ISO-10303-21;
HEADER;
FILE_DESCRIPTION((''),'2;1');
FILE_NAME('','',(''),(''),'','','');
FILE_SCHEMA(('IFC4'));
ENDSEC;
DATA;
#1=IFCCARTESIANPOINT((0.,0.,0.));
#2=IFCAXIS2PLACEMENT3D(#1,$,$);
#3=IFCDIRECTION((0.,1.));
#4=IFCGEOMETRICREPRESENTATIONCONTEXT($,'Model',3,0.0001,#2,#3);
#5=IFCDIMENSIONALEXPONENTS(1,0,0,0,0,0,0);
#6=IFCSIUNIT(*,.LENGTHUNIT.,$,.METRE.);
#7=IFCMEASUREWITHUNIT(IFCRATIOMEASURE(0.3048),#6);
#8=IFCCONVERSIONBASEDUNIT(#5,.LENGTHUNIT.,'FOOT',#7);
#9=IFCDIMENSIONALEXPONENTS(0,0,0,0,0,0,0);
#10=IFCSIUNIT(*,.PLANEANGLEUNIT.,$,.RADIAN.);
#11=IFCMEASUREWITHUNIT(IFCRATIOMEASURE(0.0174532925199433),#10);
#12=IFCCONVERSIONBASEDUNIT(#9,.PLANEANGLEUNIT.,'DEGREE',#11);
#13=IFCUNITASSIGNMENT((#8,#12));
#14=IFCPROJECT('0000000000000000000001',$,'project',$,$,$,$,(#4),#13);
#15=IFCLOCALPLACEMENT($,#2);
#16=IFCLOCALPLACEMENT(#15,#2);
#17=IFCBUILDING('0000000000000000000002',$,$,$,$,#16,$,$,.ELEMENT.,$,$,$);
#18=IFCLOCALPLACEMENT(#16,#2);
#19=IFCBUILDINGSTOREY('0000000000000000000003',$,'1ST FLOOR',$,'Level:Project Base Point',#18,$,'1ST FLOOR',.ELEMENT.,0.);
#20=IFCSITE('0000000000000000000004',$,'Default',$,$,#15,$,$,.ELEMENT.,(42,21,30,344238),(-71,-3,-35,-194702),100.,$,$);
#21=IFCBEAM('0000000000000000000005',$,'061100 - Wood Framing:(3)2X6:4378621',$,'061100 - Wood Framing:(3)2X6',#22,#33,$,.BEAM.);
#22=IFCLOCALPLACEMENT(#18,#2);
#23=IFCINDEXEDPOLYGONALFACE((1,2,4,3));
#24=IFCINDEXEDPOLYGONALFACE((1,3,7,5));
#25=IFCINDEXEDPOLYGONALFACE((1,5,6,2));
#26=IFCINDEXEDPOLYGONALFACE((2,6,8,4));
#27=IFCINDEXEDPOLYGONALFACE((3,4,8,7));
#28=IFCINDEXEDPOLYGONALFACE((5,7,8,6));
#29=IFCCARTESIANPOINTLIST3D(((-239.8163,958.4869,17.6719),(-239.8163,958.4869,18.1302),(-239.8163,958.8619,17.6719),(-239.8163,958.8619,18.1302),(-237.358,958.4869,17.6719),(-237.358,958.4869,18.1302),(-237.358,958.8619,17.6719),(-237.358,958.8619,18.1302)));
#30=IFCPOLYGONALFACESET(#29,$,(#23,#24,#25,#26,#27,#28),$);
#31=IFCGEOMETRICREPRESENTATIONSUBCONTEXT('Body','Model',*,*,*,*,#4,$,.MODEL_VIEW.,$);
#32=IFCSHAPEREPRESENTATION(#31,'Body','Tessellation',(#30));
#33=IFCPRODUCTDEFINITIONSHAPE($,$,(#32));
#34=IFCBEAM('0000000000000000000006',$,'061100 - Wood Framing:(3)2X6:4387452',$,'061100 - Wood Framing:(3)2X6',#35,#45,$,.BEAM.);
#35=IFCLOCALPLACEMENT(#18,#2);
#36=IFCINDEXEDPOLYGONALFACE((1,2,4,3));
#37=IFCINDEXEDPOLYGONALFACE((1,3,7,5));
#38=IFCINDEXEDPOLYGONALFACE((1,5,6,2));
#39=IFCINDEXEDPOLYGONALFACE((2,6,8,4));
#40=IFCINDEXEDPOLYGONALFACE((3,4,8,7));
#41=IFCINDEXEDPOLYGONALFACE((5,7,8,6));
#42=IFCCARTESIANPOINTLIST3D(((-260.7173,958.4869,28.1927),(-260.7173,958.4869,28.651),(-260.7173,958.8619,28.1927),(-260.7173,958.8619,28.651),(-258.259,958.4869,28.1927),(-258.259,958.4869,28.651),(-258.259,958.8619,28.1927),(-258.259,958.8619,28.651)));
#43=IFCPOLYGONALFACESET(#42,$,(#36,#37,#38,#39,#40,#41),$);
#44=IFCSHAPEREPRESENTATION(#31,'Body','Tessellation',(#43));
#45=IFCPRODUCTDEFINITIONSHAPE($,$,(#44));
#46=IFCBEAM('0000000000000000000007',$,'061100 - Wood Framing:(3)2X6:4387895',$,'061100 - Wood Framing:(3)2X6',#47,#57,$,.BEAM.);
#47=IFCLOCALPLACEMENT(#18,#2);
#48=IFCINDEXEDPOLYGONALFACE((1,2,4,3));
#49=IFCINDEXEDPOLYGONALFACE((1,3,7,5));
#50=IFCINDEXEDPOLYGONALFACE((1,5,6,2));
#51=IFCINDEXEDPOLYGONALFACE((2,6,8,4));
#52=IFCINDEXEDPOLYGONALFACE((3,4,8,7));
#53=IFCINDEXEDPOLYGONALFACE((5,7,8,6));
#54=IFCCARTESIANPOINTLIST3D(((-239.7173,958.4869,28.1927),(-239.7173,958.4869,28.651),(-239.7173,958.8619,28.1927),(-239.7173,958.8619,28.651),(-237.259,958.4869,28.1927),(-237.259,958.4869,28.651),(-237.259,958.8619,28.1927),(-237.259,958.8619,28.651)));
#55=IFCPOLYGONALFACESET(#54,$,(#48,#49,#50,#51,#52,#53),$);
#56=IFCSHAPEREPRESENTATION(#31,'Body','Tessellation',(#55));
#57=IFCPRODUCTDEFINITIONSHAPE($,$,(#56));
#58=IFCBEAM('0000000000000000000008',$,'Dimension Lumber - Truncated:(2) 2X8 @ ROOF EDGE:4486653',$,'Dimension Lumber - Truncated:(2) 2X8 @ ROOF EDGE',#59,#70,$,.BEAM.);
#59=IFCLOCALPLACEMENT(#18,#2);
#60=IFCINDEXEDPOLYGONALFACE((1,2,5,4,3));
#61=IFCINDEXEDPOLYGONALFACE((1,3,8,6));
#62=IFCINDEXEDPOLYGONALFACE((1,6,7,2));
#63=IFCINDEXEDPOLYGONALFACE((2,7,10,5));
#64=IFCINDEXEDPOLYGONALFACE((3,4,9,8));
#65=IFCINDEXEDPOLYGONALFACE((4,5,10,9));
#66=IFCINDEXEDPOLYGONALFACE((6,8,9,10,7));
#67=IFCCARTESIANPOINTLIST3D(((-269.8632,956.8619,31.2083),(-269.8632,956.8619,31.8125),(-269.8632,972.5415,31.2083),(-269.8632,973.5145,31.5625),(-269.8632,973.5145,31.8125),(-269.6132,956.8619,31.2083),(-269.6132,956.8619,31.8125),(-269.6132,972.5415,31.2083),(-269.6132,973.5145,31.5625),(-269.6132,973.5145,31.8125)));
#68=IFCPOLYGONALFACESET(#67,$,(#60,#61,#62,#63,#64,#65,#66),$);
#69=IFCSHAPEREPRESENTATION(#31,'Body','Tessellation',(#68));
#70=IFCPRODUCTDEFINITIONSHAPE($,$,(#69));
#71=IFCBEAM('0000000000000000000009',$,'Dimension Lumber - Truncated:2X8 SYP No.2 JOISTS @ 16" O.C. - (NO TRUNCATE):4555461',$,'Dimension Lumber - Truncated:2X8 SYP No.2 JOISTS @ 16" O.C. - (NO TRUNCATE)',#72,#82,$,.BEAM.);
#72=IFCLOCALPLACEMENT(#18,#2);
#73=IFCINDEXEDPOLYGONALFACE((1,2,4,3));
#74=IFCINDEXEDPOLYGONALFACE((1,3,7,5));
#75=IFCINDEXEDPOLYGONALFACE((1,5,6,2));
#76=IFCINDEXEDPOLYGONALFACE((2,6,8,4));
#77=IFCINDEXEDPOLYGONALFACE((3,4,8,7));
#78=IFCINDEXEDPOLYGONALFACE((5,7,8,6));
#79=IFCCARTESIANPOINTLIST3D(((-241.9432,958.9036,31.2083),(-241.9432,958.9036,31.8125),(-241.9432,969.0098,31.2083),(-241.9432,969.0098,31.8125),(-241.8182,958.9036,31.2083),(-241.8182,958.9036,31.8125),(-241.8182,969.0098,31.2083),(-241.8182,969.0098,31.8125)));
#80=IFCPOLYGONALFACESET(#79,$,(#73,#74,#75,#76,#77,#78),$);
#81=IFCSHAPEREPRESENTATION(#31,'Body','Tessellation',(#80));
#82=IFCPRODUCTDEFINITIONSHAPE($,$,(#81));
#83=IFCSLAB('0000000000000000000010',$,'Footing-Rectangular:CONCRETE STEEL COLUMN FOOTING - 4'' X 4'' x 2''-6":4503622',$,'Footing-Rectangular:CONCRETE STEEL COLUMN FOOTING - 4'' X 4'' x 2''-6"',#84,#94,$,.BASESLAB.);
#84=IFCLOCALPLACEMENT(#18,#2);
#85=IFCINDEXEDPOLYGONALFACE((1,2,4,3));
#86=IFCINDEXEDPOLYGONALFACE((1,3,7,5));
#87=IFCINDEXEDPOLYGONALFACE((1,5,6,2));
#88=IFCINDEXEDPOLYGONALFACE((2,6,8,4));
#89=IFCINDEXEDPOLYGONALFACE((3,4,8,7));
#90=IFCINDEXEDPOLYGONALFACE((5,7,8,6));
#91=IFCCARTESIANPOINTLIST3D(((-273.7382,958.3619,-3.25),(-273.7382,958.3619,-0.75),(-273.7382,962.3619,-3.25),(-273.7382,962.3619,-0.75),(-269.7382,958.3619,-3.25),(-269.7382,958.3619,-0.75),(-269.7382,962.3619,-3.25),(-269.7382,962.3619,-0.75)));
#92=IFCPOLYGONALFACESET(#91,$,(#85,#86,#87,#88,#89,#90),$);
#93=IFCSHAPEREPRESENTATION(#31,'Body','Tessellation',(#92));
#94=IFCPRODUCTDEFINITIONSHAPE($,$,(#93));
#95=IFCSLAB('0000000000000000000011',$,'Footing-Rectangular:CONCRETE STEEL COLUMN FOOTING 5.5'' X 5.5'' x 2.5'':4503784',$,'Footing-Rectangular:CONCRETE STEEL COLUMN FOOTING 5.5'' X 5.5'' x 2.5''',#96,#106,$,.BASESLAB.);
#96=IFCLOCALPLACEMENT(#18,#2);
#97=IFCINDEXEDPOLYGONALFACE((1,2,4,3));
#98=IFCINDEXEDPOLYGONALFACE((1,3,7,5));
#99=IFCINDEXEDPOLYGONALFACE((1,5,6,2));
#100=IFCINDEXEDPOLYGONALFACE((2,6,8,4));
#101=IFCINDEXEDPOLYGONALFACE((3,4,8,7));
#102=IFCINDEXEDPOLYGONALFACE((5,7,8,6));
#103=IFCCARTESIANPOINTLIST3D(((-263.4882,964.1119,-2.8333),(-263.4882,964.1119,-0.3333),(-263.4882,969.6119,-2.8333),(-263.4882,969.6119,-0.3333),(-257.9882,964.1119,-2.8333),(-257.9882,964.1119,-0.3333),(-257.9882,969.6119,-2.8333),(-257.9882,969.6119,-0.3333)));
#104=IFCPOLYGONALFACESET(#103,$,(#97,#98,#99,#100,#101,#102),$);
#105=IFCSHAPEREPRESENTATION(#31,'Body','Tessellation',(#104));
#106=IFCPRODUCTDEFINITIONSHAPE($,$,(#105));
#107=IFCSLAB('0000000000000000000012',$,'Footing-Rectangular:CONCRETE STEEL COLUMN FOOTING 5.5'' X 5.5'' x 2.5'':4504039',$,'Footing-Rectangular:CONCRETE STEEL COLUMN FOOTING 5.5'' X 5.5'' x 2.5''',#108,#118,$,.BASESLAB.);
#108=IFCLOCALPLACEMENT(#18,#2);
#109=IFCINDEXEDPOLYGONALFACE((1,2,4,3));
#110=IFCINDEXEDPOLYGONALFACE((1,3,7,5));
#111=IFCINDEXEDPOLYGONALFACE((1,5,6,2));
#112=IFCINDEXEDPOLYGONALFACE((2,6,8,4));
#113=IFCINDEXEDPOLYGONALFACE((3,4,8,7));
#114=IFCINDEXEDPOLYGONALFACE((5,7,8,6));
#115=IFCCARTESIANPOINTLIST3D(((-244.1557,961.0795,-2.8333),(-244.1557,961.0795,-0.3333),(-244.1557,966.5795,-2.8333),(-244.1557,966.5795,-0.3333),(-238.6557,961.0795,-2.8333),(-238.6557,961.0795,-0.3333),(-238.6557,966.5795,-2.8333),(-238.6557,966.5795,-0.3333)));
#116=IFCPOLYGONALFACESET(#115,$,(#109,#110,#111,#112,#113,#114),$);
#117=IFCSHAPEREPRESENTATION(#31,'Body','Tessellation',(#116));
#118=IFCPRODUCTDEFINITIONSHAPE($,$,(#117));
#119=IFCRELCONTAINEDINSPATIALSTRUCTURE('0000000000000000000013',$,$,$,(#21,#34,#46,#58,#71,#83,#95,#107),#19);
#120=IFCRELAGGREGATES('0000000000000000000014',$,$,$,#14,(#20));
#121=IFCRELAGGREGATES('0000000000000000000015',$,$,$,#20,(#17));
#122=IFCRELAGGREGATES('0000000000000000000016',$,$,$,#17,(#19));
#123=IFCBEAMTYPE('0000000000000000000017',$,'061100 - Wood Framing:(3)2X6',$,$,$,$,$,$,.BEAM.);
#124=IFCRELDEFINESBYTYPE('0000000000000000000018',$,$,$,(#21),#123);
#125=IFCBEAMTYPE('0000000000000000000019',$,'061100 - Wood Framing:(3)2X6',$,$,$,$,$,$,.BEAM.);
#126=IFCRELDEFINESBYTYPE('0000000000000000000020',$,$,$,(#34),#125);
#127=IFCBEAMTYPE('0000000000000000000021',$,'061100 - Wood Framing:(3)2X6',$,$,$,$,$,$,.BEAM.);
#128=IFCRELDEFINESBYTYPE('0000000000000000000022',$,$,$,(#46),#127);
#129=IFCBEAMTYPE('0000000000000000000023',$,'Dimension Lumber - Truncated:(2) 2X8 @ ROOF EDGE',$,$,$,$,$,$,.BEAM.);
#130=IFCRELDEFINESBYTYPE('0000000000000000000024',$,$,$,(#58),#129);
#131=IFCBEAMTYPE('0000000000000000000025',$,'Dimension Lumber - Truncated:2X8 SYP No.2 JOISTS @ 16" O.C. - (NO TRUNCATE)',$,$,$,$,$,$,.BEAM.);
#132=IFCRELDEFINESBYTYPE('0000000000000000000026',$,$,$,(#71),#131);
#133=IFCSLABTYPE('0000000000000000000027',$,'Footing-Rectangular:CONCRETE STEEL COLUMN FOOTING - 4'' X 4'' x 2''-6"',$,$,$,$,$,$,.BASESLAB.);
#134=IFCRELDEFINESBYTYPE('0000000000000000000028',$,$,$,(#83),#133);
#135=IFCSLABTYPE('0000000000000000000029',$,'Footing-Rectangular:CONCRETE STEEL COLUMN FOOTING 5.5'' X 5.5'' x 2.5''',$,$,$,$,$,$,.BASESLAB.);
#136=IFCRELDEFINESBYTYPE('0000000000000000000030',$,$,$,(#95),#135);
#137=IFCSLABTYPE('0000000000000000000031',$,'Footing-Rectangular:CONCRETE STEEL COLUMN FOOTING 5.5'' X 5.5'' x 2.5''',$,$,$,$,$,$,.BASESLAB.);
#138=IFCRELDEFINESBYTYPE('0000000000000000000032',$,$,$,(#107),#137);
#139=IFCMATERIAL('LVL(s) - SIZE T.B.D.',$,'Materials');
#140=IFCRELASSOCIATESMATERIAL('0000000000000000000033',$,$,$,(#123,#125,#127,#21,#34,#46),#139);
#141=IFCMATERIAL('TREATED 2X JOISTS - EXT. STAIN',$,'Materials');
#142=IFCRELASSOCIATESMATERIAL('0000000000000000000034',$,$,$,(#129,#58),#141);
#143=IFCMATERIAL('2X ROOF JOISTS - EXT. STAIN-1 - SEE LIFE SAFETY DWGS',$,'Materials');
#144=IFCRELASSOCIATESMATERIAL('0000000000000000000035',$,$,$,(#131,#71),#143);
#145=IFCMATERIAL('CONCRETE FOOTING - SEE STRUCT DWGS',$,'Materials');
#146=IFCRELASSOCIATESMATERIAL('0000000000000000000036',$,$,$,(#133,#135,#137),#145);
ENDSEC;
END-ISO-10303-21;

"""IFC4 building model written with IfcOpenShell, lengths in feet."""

from ifc_helpers import new_model, entity, si_unit, converted_unit, direction, frame, frame_2d, origin, origin_2d_with_axis, place, context, subcontext, project, spatial, rectangle, extrude, clip, halfspace, source, transform, mapped, material, material_profile, profile_set, profile_usage, type_object, type_shapes, element, save


model = new_model("IFC4")

# Units and contexts
model_context = context("Model", 3, precision=0.0001, world=origin(), true_north=direction((0.0, 1.0)))
body_context = subcontext(model_context, "Body", "Model", "MODEL_VIEW")
ifc_project = project(units=[converted_unit("LENGTHUNIT", "FOOT", entity("IfcRatioMeasure", 0.3048), si_unit("LENGTHUNIT", "METRE"), dimensions=[1, 0, 0, 0, 0, 0, 0]), converted_unit("PLANEANGLEUNIT", "DEGREE", entity("IfcRatioMeasure", 0.0174532925199433), si_unit("PLANEANGLEUNIT", "RADIAN"), dimensions=[0, 0, 0, 0, 0, 0, 0])], contexts=[model_context])

# Site, building, storey
site_placement = place(None, origin())
site = spatial("IfcSite", under=ifc_project, at=site_placement, Name="Default", CompositionType="ELEMENT", RefLatitude=(42, 21, 30, 344238), RefLongitude=(-71, -3, -35, -194702), RefElevation=100.0)
building_placement = place(site_placement, origin())
building = spatial("IfcBuilding", under=site, at=building_placement, CompositionType="ELEMENT")
storey_placement = place(building_placement, origin())
storey = spatial("IfcBuildingStorey", under=building, at=storey_placement, Name="1ST FLOOR", ObjectType="Level:Project Base Point", LongName="1ST FLOOR", CompositionType="ELEMENT", Elevation=0.0)

# Beams
ifc_material_1 = material(Name="LVL(s) - SIZE T.B.D.", Category="Materials")
ifc_material_profile_1 = material_profile(ifc_material_1, rectangle(XDim=0.4583, YDim=0.375, at=frame_2d((0.0, 0.0), x_axis=(1.0, 0.0))), Name="(3)2X6")
ifc_profile_set_1 = profile_set([ifc_material_profile_1], Name="(3)2X6")
ifc_profile_usage_1 = profile_usage(ifc_profile_set_1, cardinal=8)
beam_type_1 = type_object("IfcBeamType", Name="061100 - Wood Framing:(3)2X6", PredefinedType="BEAM", material=ifc_profile_set_1)
shared_shape_1 = source(origin(), body_context, "Body", "SweptSolid", [
    extrude(rectangle(XDim=0.4583, YDim=0.375, at=frame_2d((0.0, 0.0), x_axis=(1.0, 0.0))), frame((-1.2169, 0.0, 0.0), z_axis=(1.0, 0.0, 0.0), x_axis=(0.0, 0.0, -1.0)), (0.0, 0.0, 1.0), 2.4583),
])
type_shapes(beam_type_1, [shared_shape_1])
beam_1_placement = place(storey_placement, frame((-238.5993, 958.6744, 17.901)))
element("IfcBeam", 1, at=beam_1_placement, inside=storey, type_object=beam_type_1, material=ifc_profile_usage_1, Name="061100 - Wood Framing:(3)2X6:4378621", ObjectType="061100 - Wood Framing:(3)2X6", PredefinedType="BEAM", context=body_context, shape_type="MappedRepresentation", body=[
    mapped(shared_shape_1, transform((0.0, 0.0, 0.0), scale=1.0)),
])
ifc_profile_usage_2 = profile_usage(ifc_profile_set_1, cardinal=8)
beam_type_2 = type_object("IfcBeamType", Name="061100 - Wood Framing:(3)2X6", PredefinedType="BEAM", material=ifc_profile_set_1)
shared_shape_2 = source(origin(), body_context, "Body", "SweptSolid", [
    extrude(rectangle(XDim=0.4583, YDim=0.375, at=origin_2d_with_axis()), frame((-1.2191, 0.0, 0.0), z_axis=(1.0, 0.0, 0.0), x_axis=(0.0, 0.0, -1.0)), (0.0, 0.0, 1.0), 2.4583),
])
type_shapes(beam_type_2, [shared_shape_2])
beam_2_placement = place(storey_placement, frame((-259.4983, 958.6744, 28.4219)))
element("IfcBeam", 2, at=beam_2_placement, inside=storey, type_object=beam_type_2, material=ifc_profile_usage_2, Name="061100 - Wood Framing:(3)2X6:4387452", ObjectType="061100 - Wood Framing:(3)2X6", PredefinedType="BEAM", context=body_context, shape_type="MappedRepresentation", body=[
    mapped(shared_shape_2, transform((0.0, 0.0, 0.0), scale=1.0)),
])
ifc_profile_usage_3 = profile_usage(ifc_profile_set_1, cardinal=8)
beam_type_3 = type_object("IfcBeamType", Name="061100 - Wood Framing:(3)2X6", PredefinedType="BEAM", material=ifc_profile_set_1)
shared_shape_3 = source(origin(), body_context, "Body", "SweptSolid", [
    extrude(rectangle(XDim=0.4583, YDim=0.375, at=frame_2d((0.0, 0.0), x_axis=(1.0, 0.0))), frame((-1.2357, 0.0, 0.0), z_axis=(1.0, 0.0, 0.0), x_axis=(0.0, 0.0, -1.0)), (0.0, 0.0, 1.0), 2.4583),
])
type_shapes(beam_type_3, [shared_shape_3])
beam_3_placement = place(storey_placement, frame((-238.4816, 958.6744, 28.4219)))
element("IfcBeam", 3, at=beam_3_placement, inside=storey, type_object=beam_type_3, material=ifc_profile_usage_3, Name="061100 - Wood Framing:(3)2X6:4387895", ObjectType="061100 - Wood Framing:(3)2X6", PredefinedType="BEAM", context=body_context, shape_type="MappedRepresentation", body=[
    mapped(shared_shape_3, transform((0.0, 0.0, 0.0), scale=1.0)),
])
ifc_material_2 = material(Name="TREATED 2X JOISTS - EXT. STAIN", Category="Materials")
ifc_material_profile_2 = material_profile(ifc_material_2, rectangle(XDim=0.6042, YDim=0.25, at=frame_2d((0.0, 0.0), x_axis=(0.0, 1.0))), Name="(2) 2X8 @ ROOF EDGE")
ifc_profile_set_2 = profile_set([ifc_material_profile_2], Name="(2) 2X8 @ ROOF EDGE")
ifc_profile_usage_4 = profile_usage(ifc_profile_set_2, cardinal=8)
beam_type_4 = type_object("IfcBeamType", Name="Dimension Lumber - Truncated:(2) 2X8 @ ROOF EDGE", PredefinedType="BEAM", material=ifc_profile_set_2)
shared_shape_4 = source(origin(), body_context, "Body", "Clipping", [
    clip(extrude(rectangle(XDim=0.6042, YDim=0.25, at=frame_2d((0.0, 0.0), x_axis=(0.0, 1.0))), frame((-8.3263, 0.0, 0.0), z_axis=(1.0, 0.0, 0.0), x_axis=(0.0, 1.0, 0.0)), (0.0, 0.0, 1.0), 16.6526), halfspace(frame((-7.3532, -0.125, -0.3021), z_axis=(-0.34202, 0.0, -0.939693), x_axis=(0.0, 1.0, 0.0)), False)),
])
type_shapes(beam_type_4, [shared_shape_4])
beam_4_placement = place(storey_placement, frame((-269.7382, 965.1882, 31.5104), z_axis=(0.0, 0.0, 1.0), x_axis=(0.0, -1.0, 0.0)))
element("IfcBeam", 4, at=beam_4_placement, inside=storey, type_object=beam_type_4, material=ifc_profile_usage_4, Name="Dimension Lumber - Truncated:(2) 2X8 @ ROOF EDGE:4486653", ObjectType="Dimension Lumber - Truncated:(2) 2X8 @ ROOF EDGE", PredefinedType="BEAM", context=body_context, shape_type="MappedRepresentation", body=[
    mapped(shared_shape_4, transform((0.0, 0.0, 0.0), scale=1.0)),
])
ifc_material_3 = material(Name="2X ROOF JOISTS - EXT. STAIN-1 - SEE LIFE SAFETY DWGS", Category="Materials")
ifc_material_profile_3 = material_profile(ifc_material_3, rectangle(XDim=0.6042, YDim=0.125, at=frame_2d((0.0, 0.0), x_axis=(1.0, 0.0))), Name="2X8 SYP No.2 JOISTS @ 16\" O.C. - (NO TRUNCATE)")
ifc_profile_set_3 = profile_set([ifc_material_profile_3], Name="2X8 SYP No.2 JOISTS @ 16\" O.C. - (NO TRUNCATE)")
ifc_profile_usage_5 = profile_usage(ifc_profile_set_3, cardinal=8)
beam_type_5 = type_object("IfcBeamType", Name="Dimension Lumber - Truncated:2X8 SYP No.2 JOISTS @ 16\" O.C. - (NO TRUNCATE)", PredefinedType="BEAM", material=ifc_profile_set_3)
shared_shape_5 = source(origin(), body_context, "Body", "SweptSolid", [
    extrude(rectangle(XDim=0.6042, YDim=0.125, at=frame_2d((0.0, 0.0), x_axis=(1.0, 0.0))), frame((-5.0531, 0.0, 0.0), z_axis=(1.0, 0.0, 0.0), x_axis=(0.0, 0.0, -1.0)), (0.0, 0.0, 1.0), 10.1062),
])
type_shapes(beam_type_5, [shared_shape_5])
beam_5_placement = place(storey_placement, frame((-241.8807, 963.9567, 31.5104), z_axis=(0.0, 0.0, 1.0), x_axis=(0.0, -1.0, 0.0)))
element("IfcBeam", 5, at=beam_5_placement, inside=storey, type_object=beam_type_5, material=ifc_profile_usage_5, Name="Dimension Lumber - Truncated:2X8 SYP No.2 JOISTS @ 16\" O.C. - (NO TRUNCATE):4555461", ObjectType="Dimension Lumber - Truncated:2X8 SYP No.2 JOISTS @ 16\" O.C. - (NO TRUNCATE)", PredefinedType="BEAM", context=body_context, shape_type="MappedRepresentation", body=[
    mapped(shared_shape_5, transform((0.0, 0.0, 0.0), scale=1.0)),
])

# Slabs
ifc_material_4 = material(Name="CONCRETE FOOTING - SEE STRUCT DWGS", Category="Materials")
slab_type_1 = type_object("IfcSlabType", Name="Footing-Rectangular:CONCRETE STEEL COLUMN FOOTING - 4' X 4' x 2'-6\"", PredefinedType="BASESLAB", material=ifc_material_4)
slab_1_placement = place(storey_placement, frame((-273.7382, 958.3619, -3.25)))
element("IfcSlab", 6, at=slab_1_placement, inside=storey, type_object=slab_type_1, Name="Footing-Rectangular:CONCRETE STEEL COLUMN FOOTING - 4' X 4' x 2'-6\":4503622", ObjectType="Footing-Rectangular:CONCRETE STEEL COLUMN FOOTING - 4' X 4' x 2'-6\"", PredefinedType="BASESLAB", context=body_context, shape_type="SweptSolid", body=[
    extrude(rectangle(XDim=4.0, YDim=4.0, at=origin_2d_with_axis()), frame((2.0, 2.0, 0.0), z_axis=(0.0, 0.0, 1.0), x_axis=(-1.0, 0.0, 0.0)), (0.0, 0.0, 1.0), 2.5),
])
slab_type_2 = type_object("IfcSlabType", Name="Footing-Rectangular:CONCRETE STEEL COLUMN FOOTING 5.5' X 5.5' x 2.5'", PredefinedType="BASESLAB", material=ifc_material_4)
slab_2_placement = place(storey_placement, frame((-263.4882, 964.1119, -2.8333)))
element("IfcSlab", 7, at=slab_2_placement, inside=storey, type_object=slab_type_2, Name="Footing-Rectangular:CONCRETE STEEL COLUMN FOOTING 5.5' X 5.5' x 2.5':4503784", ObjectType="Footing-Rectangular:CONCRETE STEEL COLUMN FOOTING 5.5' X 5.5' x 2.5'", PredefinedType="BASESLAB", context=body_context, shape_type="SweptSolid", body=[
    extrude(rectangle(XDim=5.5, YDim=5.5, at=frame_2d((0.0, 0.0), x_axis=(1.0, 0.0))), frame((2.75, 2.75, 0.0), z_axis=(0.0, 0.0, 1.0), x_axis=(-1.0, 0.0, 0.0)), (0.0, 0.0, 1.0), 2.5),
])
slab_type_3 = type_object("IfcSlabType", Name="Footing-Rectangular:CONCRETE STEEL COLUMN FOOTING 5.5' X 5.5' x 2.5'", PredefinedType="BASESLAB", material=ifc_material_4)
slab_3_placement = place(storey_placement, frame((-244.1557, 961.0795, -2.8333)))
element("IfcSlab", 8, at=slab_3_placement, inside=storey, type_object=slab_type_3, Name="Footing-Rectangular:CONCRETE STEEL COLUMN FOOTING 5.5' X 5.5' x 2.5':4504039", ObjectType="Footing-Rectangular:CONCRETE STEEL COLUMN FOOTING 5.5' X 5.5' x 2.5'", PredefinedType="BASESLAB", context=body_context, shape_type="SweptSolid", body=[
    extrude(rectangle(XDim=5.5, YDim=5.5, at=frame_2d((0.0, 0.0), x_axis=(1.0, 0.0))), frame((2.75, 2.75, 0.0), z_axis=(0.0, 0.0, 1.0), x_axis=(-1.0, 0.0, 0.0)), (0.0, 0.0, 1.0), 2.5),
])

save(model, "model.ifc")
